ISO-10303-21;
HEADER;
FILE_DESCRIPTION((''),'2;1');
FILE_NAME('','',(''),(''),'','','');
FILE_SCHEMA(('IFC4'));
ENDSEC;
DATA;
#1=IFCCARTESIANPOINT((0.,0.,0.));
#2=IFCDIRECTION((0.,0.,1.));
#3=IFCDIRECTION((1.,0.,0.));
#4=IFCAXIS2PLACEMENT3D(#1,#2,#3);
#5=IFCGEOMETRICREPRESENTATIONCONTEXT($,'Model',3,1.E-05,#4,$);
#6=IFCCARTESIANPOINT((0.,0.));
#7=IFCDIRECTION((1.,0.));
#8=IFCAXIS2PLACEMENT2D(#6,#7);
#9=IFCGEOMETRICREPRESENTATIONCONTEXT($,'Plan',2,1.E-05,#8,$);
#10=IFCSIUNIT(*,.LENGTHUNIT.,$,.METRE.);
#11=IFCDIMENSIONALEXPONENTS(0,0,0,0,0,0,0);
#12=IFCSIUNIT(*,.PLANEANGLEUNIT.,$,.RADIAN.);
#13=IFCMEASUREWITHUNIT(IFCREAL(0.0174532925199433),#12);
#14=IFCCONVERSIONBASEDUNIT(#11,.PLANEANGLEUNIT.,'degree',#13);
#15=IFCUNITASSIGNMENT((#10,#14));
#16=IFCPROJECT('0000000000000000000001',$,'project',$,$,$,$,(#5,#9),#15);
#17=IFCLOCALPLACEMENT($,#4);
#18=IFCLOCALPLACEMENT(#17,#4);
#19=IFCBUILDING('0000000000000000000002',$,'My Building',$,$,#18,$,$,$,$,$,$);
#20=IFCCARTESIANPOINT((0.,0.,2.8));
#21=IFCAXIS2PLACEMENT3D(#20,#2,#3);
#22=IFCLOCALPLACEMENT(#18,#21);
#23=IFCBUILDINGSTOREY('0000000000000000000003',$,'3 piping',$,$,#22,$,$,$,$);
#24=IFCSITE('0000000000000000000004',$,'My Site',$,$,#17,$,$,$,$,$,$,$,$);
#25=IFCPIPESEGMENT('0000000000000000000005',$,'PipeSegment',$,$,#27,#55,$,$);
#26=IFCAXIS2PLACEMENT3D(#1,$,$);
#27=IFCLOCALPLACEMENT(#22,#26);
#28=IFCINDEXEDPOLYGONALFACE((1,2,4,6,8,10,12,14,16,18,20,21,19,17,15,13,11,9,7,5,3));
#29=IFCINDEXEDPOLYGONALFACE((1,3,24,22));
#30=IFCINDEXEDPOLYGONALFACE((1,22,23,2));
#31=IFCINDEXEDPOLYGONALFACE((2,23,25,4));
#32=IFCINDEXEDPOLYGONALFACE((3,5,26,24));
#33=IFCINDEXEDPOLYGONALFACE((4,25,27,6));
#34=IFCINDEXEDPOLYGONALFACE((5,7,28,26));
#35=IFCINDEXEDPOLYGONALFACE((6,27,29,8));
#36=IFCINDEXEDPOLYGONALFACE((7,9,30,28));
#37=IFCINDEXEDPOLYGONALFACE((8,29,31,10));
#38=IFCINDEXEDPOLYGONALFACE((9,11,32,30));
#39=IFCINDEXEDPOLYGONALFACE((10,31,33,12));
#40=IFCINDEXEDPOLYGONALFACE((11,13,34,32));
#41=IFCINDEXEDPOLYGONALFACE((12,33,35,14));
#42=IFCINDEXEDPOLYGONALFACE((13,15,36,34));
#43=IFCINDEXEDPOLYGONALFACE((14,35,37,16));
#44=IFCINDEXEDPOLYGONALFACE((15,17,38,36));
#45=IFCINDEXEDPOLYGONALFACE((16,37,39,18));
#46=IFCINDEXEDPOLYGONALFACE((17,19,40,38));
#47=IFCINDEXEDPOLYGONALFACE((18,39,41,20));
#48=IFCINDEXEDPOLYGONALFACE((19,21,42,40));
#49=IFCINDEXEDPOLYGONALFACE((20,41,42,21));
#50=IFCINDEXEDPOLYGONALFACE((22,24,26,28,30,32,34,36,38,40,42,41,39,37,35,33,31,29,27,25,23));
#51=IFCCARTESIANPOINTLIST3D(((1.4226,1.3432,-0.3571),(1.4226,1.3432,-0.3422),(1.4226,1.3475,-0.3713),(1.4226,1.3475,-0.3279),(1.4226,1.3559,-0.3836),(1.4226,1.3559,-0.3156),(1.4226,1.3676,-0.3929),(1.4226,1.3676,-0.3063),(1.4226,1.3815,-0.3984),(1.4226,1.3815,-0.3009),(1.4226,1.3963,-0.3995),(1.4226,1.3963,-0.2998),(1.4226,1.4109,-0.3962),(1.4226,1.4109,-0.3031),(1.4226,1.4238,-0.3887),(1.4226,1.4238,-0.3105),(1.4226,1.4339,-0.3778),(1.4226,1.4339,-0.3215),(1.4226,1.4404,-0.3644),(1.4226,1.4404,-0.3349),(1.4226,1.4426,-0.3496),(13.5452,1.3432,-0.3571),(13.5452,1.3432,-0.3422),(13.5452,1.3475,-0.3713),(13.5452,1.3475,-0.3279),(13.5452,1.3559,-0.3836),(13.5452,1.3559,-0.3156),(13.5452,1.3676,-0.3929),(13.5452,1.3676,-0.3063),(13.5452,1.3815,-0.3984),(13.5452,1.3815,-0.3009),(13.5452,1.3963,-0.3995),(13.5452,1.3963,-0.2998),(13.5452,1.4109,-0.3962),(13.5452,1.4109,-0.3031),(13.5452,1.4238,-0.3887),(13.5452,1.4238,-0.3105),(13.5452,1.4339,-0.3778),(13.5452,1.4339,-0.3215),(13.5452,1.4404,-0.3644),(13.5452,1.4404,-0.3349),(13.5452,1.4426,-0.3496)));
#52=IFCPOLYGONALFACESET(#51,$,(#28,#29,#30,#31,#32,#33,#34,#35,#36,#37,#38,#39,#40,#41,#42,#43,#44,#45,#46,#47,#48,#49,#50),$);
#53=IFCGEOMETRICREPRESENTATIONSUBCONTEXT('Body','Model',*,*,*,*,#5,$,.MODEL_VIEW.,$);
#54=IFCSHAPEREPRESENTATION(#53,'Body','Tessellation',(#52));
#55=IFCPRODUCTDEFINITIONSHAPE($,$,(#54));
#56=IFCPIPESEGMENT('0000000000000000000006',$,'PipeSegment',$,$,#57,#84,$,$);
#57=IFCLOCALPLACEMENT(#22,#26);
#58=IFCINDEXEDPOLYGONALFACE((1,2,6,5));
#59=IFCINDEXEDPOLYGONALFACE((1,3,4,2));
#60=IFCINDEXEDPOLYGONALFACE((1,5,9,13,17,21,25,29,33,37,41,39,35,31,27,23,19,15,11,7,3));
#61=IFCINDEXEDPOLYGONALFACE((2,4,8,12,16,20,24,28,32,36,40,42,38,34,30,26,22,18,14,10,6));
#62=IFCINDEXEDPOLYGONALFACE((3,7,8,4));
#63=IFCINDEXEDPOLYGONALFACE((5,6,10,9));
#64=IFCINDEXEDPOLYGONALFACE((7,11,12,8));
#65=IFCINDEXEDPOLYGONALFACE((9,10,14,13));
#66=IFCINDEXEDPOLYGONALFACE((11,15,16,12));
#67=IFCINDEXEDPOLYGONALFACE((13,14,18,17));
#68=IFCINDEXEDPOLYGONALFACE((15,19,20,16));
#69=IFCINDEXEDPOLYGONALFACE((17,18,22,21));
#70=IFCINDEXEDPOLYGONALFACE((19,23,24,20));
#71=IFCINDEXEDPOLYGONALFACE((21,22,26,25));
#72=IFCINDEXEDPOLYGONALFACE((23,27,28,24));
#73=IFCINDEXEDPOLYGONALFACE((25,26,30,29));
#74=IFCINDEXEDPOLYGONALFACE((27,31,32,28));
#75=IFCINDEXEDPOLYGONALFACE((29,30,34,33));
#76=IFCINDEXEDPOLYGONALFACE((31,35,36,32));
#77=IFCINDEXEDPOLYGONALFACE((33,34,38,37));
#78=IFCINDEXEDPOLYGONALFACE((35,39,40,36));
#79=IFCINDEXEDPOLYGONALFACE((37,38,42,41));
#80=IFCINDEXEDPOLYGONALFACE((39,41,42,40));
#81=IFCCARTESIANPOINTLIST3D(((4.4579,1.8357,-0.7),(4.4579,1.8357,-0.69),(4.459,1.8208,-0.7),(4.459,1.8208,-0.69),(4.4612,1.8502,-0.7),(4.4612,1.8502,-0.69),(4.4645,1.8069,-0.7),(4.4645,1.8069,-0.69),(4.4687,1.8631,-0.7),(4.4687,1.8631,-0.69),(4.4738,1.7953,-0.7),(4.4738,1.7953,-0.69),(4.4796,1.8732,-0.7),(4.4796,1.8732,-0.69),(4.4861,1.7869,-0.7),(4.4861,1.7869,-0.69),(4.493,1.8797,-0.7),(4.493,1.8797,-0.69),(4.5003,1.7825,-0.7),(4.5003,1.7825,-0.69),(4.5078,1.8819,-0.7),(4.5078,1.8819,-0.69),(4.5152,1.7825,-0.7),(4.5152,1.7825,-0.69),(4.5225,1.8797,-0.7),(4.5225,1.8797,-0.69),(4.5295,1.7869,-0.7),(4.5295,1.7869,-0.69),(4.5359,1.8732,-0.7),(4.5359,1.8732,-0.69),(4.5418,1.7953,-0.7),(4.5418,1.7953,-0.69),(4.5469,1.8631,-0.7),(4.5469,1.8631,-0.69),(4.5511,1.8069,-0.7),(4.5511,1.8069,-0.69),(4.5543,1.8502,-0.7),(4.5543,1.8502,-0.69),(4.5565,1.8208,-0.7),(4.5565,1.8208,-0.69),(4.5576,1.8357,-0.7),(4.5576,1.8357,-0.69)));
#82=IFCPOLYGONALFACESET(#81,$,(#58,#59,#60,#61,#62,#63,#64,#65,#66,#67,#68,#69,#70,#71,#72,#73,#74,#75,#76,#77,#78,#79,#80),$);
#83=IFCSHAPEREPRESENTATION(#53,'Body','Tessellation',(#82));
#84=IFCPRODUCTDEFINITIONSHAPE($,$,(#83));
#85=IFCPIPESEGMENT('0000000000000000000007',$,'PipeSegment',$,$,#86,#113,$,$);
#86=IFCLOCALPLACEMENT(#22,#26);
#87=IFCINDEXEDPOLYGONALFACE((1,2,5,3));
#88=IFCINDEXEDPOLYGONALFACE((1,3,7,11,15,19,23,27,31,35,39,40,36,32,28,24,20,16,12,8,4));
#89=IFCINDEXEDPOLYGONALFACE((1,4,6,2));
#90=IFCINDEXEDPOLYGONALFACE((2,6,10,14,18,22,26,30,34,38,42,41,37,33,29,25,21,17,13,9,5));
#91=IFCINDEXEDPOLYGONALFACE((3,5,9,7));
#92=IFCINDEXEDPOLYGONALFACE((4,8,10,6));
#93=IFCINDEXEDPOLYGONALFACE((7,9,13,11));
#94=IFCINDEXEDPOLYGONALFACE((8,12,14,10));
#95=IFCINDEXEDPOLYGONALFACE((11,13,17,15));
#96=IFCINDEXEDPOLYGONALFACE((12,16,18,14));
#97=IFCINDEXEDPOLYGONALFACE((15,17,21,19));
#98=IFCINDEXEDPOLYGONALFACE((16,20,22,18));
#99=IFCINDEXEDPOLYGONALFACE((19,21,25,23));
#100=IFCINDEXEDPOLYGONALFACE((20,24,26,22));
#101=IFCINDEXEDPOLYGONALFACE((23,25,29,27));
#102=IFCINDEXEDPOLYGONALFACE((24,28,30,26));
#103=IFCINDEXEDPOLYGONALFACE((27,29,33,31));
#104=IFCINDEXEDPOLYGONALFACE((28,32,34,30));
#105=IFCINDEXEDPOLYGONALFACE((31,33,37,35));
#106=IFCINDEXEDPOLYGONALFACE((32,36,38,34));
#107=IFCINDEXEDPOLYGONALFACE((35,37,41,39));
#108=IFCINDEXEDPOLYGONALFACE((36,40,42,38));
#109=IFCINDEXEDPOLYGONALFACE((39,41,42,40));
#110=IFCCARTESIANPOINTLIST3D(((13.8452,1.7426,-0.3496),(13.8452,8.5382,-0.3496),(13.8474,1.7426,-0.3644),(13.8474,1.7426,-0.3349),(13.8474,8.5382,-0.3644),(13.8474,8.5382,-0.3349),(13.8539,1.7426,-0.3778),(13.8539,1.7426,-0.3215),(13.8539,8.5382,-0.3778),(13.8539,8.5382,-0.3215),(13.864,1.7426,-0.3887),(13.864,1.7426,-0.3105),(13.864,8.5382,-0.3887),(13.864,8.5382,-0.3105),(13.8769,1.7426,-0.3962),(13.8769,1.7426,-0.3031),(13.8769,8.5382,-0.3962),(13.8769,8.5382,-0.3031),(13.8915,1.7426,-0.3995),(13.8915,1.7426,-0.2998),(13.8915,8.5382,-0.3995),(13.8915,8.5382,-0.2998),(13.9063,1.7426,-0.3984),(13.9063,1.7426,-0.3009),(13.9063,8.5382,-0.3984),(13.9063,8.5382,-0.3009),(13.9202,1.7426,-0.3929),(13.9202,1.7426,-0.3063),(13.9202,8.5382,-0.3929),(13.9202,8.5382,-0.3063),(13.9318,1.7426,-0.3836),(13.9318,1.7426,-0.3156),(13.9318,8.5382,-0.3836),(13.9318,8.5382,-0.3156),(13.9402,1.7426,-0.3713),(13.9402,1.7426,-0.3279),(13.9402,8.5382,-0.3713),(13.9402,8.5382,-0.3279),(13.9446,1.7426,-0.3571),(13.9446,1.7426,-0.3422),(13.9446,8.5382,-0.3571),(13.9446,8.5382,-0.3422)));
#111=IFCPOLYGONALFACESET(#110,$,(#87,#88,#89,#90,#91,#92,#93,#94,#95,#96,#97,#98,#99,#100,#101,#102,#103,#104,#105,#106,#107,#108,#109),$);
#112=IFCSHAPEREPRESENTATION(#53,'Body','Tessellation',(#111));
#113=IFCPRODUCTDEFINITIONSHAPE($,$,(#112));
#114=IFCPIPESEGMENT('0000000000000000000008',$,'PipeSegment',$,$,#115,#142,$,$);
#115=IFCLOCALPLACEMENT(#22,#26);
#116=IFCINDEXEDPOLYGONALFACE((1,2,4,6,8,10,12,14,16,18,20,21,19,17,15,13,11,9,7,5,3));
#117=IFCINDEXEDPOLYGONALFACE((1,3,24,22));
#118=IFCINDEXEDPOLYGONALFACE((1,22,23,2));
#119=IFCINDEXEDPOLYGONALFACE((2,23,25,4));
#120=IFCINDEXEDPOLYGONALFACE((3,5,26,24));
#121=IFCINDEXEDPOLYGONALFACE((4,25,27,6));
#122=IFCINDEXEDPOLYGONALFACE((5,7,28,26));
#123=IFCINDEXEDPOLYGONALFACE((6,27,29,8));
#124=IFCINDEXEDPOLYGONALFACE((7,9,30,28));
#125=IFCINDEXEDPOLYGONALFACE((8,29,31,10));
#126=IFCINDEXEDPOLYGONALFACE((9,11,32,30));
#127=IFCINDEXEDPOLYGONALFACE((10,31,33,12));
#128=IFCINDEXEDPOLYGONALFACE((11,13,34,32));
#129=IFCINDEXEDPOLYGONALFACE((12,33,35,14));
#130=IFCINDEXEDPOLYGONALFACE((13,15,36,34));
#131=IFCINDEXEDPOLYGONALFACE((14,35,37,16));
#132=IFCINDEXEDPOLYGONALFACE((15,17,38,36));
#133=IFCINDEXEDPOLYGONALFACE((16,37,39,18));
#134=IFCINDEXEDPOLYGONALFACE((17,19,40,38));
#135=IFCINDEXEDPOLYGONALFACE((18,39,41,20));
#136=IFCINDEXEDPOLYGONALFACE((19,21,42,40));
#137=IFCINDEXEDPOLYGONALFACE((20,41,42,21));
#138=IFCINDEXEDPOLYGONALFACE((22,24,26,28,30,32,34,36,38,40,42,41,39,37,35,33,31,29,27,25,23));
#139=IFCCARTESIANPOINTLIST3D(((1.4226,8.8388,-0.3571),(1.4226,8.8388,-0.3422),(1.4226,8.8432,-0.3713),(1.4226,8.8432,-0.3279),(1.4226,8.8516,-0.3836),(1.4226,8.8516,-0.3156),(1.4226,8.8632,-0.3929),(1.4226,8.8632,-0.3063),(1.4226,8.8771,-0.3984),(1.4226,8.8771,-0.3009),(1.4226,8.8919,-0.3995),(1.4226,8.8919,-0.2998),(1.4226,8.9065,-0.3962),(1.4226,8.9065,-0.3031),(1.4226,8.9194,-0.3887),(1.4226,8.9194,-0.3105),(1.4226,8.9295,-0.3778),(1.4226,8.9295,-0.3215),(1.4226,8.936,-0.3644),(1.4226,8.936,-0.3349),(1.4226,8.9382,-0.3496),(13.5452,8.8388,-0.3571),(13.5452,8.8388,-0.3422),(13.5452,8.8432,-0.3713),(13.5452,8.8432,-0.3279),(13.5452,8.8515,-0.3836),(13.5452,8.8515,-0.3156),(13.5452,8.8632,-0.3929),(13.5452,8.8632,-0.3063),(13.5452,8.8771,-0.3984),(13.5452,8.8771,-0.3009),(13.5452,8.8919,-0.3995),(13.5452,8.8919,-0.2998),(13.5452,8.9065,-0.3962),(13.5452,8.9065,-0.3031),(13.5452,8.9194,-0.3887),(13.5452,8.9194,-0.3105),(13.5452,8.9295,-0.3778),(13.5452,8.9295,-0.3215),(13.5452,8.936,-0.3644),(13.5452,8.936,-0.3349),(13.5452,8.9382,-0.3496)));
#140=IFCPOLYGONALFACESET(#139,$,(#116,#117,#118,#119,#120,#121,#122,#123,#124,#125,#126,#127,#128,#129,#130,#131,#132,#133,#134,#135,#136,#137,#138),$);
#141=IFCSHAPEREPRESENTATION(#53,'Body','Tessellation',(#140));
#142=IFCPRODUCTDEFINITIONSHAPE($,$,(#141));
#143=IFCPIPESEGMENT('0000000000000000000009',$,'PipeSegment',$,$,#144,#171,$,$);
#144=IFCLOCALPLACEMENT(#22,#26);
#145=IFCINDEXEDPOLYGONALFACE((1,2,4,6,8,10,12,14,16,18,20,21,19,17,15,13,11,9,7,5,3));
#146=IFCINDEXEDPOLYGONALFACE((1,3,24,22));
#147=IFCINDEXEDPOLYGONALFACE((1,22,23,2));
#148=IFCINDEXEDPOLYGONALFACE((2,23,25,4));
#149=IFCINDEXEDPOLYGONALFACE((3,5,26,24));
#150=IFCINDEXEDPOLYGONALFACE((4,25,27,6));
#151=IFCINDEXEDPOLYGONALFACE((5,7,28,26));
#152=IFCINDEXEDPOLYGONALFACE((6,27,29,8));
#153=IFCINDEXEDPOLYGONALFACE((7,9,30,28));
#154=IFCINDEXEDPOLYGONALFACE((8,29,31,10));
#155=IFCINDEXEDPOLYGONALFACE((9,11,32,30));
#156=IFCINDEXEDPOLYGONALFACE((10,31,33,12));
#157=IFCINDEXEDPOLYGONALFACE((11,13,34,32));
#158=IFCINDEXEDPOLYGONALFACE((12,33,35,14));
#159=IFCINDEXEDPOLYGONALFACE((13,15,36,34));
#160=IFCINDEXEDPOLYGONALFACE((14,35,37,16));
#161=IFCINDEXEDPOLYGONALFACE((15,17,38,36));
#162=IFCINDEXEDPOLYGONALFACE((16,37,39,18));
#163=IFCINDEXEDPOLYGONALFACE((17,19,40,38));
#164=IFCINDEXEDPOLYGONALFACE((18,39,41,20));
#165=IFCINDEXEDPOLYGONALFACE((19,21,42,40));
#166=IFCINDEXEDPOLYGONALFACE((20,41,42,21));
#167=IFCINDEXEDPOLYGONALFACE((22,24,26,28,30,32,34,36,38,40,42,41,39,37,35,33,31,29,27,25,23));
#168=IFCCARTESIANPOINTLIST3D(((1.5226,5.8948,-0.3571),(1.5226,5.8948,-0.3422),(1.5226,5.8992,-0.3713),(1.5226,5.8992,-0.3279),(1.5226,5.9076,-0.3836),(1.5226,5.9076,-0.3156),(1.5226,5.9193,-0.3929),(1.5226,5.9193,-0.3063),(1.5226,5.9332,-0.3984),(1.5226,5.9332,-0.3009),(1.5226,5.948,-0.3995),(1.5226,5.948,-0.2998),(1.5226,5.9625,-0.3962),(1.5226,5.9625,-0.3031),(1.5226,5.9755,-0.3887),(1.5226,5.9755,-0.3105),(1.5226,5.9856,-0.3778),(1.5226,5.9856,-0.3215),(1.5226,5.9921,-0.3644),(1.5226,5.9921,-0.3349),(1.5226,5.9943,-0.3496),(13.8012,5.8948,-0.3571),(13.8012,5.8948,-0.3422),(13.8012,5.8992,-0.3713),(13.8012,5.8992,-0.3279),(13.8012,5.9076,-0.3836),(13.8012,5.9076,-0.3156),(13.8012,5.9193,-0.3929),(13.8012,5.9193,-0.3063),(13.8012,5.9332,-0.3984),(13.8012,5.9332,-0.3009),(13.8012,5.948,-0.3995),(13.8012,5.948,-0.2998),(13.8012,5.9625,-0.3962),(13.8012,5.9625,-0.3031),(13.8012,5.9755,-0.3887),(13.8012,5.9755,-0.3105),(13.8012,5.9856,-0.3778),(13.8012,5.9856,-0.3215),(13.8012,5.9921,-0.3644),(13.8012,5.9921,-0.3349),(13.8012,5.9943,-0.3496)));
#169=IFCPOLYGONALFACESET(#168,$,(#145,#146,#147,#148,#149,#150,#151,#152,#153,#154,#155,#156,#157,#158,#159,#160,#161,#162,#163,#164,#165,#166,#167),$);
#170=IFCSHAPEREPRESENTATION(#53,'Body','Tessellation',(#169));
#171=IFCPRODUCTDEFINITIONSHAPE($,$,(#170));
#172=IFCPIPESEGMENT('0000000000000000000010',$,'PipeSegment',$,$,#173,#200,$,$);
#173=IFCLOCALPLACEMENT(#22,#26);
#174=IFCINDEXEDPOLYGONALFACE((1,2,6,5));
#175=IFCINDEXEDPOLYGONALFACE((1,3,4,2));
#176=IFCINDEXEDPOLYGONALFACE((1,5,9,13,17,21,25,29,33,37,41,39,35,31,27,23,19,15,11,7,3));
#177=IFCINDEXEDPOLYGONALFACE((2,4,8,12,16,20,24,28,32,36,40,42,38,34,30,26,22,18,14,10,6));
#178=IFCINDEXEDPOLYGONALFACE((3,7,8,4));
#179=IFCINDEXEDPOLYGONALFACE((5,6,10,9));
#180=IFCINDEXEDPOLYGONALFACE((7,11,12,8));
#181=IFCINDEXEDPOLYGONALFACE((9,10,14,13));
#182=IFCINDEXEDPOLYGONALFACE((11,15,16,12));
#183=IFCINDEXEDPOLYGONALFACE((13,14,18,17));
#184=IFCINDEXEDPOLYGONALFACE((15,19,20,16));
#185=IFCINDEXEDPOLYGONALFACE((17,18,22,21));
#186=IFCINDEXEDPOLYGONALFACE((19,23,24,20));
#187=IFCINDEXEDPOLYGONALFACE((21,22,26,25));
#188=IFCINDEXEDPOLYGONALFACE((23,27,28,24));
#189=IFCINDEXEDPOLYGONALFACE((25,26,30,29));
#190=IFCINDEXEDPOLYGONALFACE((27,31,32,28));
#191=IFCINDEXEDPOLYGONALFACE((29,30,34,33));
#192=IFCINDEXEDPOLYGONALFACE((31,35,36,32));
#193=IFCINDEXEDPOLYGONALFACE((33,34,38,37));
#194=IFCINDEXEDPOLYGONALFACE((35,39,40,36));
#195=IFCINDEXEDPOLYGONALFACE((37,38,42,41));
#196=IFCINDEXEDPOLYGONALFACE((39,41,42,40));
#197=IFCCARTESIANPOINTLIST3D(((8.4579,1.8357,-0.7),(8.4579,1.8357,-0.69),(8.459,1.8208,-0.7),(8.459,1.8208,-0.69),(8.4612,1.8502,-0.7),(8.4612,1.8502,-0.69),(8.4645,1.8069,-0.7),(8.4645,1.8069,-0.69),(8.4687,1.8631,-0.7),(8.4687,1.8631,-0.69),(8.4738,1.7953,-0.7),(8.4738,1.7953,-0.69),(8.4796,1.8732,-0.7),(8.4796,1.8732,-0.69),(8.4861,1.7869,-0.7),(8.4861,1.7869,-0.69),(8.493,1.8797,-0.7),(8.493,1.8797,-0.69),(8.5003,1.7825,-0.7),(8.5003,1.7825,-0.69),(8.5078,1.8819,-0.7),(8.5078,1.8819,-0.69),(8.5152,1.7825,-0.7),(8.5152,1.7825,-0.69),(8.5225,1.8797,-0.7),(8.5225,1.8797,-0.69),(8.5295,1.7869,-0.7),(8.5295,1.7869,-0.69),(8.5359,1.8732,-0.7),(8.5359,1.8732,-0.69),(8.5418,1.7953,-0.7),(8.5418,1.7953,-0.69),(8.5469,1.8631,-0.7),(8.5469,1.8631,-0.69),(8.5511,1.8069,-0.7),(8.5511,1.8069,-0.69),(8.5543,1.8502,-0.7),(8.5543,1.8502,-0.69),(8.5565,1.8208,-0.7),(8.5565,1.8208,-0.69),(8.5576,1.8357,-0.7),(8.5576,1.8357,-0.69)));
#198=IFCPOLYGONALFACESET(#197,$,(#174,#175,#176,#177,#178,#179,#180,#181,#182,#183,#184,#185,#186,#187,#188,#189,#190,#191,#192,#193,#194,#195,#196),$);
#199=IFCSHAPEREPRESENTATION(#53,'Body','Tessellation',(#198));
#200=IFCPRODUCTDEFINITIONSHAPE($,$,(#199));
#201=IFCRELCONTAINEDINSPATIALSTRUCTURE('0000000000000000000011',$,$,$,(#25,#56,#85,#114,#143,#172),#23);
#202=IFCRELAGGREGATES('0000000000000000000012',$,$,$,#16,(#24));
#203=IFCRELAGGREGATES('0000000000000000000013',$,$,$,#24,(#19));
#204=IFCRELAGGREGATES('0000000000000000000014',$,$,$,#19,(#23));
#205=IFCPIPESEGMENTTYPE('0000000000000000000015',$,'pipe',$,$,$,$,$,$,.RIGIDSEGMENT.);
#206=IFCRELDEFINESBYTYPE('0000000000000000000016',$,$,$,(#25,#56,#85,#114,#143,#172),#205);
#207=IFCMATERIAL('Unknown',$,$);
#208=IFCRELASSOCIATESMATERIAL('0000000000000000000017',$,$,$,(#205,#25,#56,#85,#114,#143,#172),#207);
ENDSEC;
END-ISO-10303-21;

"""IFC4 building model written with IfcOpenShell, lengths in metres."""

from ifc_helpers import new_model, entity, si_unit, converted_unit, frame, origin_with_axes, origin_2d_with_axis, place, context, subcontext, project, spatial, circle, extrude, material, material_profile, profile_set, profile_usage, type_object, element, save


model = new_model("IFC4")

# Units and contexts
model_context = context("Model", 3, precision=1e-05, world=origin_with_axes())
plan_context = context("Plan", 2, precision=1e-05, world=origin_2d_with_axis())
body_context = subcontext(model_context, "Body", "Model", "MODEL_VIEW")
ifc_project = project(units=[si_unit("LENGTHUNIT", "METRE"), converted_unit("PLANEANGLEUNIT", "degree", entity("IfcReal", 0.0174532925199433), si_unit("PLANEANGLEUNIT", "RADIAN"), dimensions=[0, 0, 0, 0, 0, 0, 0])], contexts=[model_context, plan_context])

# Site, building, storey
site_placement = place(None, origin_with_axes())
site = spatial("IfcSite", under=ifc_project, at=site_placement, Name="My Site")
building_placement = place(site_placement, origin_with_axes())
building = spatial("IfcBuilding", under=site, at=building_placement, Name="My Building")
storey_placement = place(building_placement, frame((0.0, 0.0, 2.8), z_axis=(0.0, 0.0, 1.0), x_axis=(1.0, 0.0, 0.0)))
storey = spatial("IfcBuildingStorey", under=building, at=storey_placement, Name="3 piping")

# Pipe segments
ifc_material = material(Name="Unknown")
ifc_material_profile_1 = material_profile(ifc_material, circle(Radius=0.05))
ifc_profile_set_1 = profile_set([ifc_material_profile_1])
ifc_profile_usage_1 = profile_usage(ifc_profile_set_1, cardinal=2)
pipe_segment_type = type_object("IfcPipeSegmentType", Name="pipe", PredefinedType="RIGIDSEGMENT", material=ifc_profile_set_1)
pipe_segment_1_placement = place(storey_placement, frame((1.4226, 1.3926, -0.3996), z_axis=(1.0, 0.0, 0.0), x_axis=(0.0, 1.0, 0.0)))
element("IfcPipeSegment", 1, at=pipe_segment_1_placement, inside=storey, type_object=pipe_segment_type, material=ifc_profile_usage_1, Name="PipeSegment", context=body_context, shape_type="SweptSolid", body=[
    extrude(circle(Radius=0.05), frame((0.0, 0.05, 0.0), z_axis=(0.0, 0.0, 1.0), x_axis=(1.0, 0.0, 0.0)), (0.0, 0.0, 1.0), 12.1226),
])
ifc_profile_usage_2 = profile_usage(ifc_profile_set_1, cardinal=2)
pipe_segment_2_placement = place(storey_placement, frame((4.4578, 1.8319, -0.69), z_axis=(0.0, 0.0, -1.0), x_axis=(0.0, 1.0, 0.0)))
element("IfcPipeSegment", 2, at=pipe_segment_2_placement, inside=storey, type_object=pipe_segment_type, material=ifc_profile_usage_2, Name="PipeSegment", context=body_context, shape_type="SweptSolid", body=[
    extrude(circle(Radius=0.05), frame((0.0, 0.05, 0.0), z_axis=(0.0, 0.0, 1.0), x_axis=(1.0, 0.0, 0.0)), (0.0, 0.0, 1.0), 0.01),
])
ifc_profile_usage_3 = profile_usage(ifc_profile_set_1, cardinal=2)
pipe_segment_3_placement = place(storey_placement, frame((13.8952, 1.7426, -0.3996), z_axis=(0.0, 1.0, 0.0), x_axis=(-1.0, 0.0, 0.0)))
element("IfcPipeSegment", 3, at=pipe_segment_3_placement, inside=storey, type_object=pipe_segment_type, material=ifc_profile_usage_3, Name="PipeSegment", context=body_context, shape_type="SweptSolid", body=[
    extrude(circle(Radius=0.05), frame((0.0, 0.05, 0.0), z_axis=(0.0, 0.0, 1.0), x_axis=(1.0, 0.0, 0.0)), (0.0, 0.0, 1.0), 6.7956),
])
ifc_profile_usage_4 = profile_usage(ifc_profile_set_1, cardinal=2)
pipe_segment_4_placement = place(storey_placement, frame((1.4226, 8.8882, -0.3996), z_axis=(1.0, 0.0, 0.0), x_axis=(0.0, 1.0, 0.0)))
element("IfcPipeSegment", 4, at=pipe_segment_4_placement, inside=storey, type_object=pipe_segment_type, material=ifc_profile_usage_4, Name="PipeSegment", context=body_context, shape_type="SweptSolid", body=[
    extrude(circle(Radius=0.05), frame((0.0, 0.05, 0.0), z_axis=(0.0, 0.0, 1.0), x_axis=(1.0, 0.0, 0.0)), (0.0, 0.0, 1.0), 12.1226),
])
ifc_profile_usage_5 = profile_usage(ifc_profile_set_1, cardinal=2)
pipe_segment_5_placement = place(storey_placement, frame((1.5226, 5.9443, -0.3996), z_axis=(1.0, 0.0, 0.0), x_axis=(0.0, 1.0, 0.0)))
element("IfcPipeSegment", 5, at=pipe_segment_5_placement, inside=storey, type_object=pipe_segment_type, material=ifc_profile_usage_5, Name="PipeSegment", context=body_context, shape_type="SweptSolid", body=[
    extrude(circle(Radius=0.05), frame((0.0, 0.05, 0.0), z_axis=(0.0, 0.0, 1.0), x_axis=(1.0, 0.0, 0.0)), (0.0, 0.0, 1.0), 12.2786),
])
ifc_profile_usage_6 = profile_usage(ifc_profile_set_1, cardinal=2)
pipe_segment_6_placement = place(storey_placement, frame((8.4578, 1.8319, -0.69), z_axis=(0.0, 0.0, -1.0), x_axis=(0.0, 1.0, 0.0)))
element("IfcPipeSegment", 6, at=pipe_segment_6_placement, inside=storey, type_object=pipe_segment_type, material=ifc_profile_usage_6, Name="PipeSegment", context=body_context, shape_type="SweptSolid", body=[
    extrude(circle(Radius=0.05), frame((0.0, 0.05, 0.0), z_axis=(0.0, 0.0, 1.0), x_axis=(1.0, 0.0, 0.0)), (0.0, 0.0, 1.0), 0.01),
])

save(model, "model.ifc")
